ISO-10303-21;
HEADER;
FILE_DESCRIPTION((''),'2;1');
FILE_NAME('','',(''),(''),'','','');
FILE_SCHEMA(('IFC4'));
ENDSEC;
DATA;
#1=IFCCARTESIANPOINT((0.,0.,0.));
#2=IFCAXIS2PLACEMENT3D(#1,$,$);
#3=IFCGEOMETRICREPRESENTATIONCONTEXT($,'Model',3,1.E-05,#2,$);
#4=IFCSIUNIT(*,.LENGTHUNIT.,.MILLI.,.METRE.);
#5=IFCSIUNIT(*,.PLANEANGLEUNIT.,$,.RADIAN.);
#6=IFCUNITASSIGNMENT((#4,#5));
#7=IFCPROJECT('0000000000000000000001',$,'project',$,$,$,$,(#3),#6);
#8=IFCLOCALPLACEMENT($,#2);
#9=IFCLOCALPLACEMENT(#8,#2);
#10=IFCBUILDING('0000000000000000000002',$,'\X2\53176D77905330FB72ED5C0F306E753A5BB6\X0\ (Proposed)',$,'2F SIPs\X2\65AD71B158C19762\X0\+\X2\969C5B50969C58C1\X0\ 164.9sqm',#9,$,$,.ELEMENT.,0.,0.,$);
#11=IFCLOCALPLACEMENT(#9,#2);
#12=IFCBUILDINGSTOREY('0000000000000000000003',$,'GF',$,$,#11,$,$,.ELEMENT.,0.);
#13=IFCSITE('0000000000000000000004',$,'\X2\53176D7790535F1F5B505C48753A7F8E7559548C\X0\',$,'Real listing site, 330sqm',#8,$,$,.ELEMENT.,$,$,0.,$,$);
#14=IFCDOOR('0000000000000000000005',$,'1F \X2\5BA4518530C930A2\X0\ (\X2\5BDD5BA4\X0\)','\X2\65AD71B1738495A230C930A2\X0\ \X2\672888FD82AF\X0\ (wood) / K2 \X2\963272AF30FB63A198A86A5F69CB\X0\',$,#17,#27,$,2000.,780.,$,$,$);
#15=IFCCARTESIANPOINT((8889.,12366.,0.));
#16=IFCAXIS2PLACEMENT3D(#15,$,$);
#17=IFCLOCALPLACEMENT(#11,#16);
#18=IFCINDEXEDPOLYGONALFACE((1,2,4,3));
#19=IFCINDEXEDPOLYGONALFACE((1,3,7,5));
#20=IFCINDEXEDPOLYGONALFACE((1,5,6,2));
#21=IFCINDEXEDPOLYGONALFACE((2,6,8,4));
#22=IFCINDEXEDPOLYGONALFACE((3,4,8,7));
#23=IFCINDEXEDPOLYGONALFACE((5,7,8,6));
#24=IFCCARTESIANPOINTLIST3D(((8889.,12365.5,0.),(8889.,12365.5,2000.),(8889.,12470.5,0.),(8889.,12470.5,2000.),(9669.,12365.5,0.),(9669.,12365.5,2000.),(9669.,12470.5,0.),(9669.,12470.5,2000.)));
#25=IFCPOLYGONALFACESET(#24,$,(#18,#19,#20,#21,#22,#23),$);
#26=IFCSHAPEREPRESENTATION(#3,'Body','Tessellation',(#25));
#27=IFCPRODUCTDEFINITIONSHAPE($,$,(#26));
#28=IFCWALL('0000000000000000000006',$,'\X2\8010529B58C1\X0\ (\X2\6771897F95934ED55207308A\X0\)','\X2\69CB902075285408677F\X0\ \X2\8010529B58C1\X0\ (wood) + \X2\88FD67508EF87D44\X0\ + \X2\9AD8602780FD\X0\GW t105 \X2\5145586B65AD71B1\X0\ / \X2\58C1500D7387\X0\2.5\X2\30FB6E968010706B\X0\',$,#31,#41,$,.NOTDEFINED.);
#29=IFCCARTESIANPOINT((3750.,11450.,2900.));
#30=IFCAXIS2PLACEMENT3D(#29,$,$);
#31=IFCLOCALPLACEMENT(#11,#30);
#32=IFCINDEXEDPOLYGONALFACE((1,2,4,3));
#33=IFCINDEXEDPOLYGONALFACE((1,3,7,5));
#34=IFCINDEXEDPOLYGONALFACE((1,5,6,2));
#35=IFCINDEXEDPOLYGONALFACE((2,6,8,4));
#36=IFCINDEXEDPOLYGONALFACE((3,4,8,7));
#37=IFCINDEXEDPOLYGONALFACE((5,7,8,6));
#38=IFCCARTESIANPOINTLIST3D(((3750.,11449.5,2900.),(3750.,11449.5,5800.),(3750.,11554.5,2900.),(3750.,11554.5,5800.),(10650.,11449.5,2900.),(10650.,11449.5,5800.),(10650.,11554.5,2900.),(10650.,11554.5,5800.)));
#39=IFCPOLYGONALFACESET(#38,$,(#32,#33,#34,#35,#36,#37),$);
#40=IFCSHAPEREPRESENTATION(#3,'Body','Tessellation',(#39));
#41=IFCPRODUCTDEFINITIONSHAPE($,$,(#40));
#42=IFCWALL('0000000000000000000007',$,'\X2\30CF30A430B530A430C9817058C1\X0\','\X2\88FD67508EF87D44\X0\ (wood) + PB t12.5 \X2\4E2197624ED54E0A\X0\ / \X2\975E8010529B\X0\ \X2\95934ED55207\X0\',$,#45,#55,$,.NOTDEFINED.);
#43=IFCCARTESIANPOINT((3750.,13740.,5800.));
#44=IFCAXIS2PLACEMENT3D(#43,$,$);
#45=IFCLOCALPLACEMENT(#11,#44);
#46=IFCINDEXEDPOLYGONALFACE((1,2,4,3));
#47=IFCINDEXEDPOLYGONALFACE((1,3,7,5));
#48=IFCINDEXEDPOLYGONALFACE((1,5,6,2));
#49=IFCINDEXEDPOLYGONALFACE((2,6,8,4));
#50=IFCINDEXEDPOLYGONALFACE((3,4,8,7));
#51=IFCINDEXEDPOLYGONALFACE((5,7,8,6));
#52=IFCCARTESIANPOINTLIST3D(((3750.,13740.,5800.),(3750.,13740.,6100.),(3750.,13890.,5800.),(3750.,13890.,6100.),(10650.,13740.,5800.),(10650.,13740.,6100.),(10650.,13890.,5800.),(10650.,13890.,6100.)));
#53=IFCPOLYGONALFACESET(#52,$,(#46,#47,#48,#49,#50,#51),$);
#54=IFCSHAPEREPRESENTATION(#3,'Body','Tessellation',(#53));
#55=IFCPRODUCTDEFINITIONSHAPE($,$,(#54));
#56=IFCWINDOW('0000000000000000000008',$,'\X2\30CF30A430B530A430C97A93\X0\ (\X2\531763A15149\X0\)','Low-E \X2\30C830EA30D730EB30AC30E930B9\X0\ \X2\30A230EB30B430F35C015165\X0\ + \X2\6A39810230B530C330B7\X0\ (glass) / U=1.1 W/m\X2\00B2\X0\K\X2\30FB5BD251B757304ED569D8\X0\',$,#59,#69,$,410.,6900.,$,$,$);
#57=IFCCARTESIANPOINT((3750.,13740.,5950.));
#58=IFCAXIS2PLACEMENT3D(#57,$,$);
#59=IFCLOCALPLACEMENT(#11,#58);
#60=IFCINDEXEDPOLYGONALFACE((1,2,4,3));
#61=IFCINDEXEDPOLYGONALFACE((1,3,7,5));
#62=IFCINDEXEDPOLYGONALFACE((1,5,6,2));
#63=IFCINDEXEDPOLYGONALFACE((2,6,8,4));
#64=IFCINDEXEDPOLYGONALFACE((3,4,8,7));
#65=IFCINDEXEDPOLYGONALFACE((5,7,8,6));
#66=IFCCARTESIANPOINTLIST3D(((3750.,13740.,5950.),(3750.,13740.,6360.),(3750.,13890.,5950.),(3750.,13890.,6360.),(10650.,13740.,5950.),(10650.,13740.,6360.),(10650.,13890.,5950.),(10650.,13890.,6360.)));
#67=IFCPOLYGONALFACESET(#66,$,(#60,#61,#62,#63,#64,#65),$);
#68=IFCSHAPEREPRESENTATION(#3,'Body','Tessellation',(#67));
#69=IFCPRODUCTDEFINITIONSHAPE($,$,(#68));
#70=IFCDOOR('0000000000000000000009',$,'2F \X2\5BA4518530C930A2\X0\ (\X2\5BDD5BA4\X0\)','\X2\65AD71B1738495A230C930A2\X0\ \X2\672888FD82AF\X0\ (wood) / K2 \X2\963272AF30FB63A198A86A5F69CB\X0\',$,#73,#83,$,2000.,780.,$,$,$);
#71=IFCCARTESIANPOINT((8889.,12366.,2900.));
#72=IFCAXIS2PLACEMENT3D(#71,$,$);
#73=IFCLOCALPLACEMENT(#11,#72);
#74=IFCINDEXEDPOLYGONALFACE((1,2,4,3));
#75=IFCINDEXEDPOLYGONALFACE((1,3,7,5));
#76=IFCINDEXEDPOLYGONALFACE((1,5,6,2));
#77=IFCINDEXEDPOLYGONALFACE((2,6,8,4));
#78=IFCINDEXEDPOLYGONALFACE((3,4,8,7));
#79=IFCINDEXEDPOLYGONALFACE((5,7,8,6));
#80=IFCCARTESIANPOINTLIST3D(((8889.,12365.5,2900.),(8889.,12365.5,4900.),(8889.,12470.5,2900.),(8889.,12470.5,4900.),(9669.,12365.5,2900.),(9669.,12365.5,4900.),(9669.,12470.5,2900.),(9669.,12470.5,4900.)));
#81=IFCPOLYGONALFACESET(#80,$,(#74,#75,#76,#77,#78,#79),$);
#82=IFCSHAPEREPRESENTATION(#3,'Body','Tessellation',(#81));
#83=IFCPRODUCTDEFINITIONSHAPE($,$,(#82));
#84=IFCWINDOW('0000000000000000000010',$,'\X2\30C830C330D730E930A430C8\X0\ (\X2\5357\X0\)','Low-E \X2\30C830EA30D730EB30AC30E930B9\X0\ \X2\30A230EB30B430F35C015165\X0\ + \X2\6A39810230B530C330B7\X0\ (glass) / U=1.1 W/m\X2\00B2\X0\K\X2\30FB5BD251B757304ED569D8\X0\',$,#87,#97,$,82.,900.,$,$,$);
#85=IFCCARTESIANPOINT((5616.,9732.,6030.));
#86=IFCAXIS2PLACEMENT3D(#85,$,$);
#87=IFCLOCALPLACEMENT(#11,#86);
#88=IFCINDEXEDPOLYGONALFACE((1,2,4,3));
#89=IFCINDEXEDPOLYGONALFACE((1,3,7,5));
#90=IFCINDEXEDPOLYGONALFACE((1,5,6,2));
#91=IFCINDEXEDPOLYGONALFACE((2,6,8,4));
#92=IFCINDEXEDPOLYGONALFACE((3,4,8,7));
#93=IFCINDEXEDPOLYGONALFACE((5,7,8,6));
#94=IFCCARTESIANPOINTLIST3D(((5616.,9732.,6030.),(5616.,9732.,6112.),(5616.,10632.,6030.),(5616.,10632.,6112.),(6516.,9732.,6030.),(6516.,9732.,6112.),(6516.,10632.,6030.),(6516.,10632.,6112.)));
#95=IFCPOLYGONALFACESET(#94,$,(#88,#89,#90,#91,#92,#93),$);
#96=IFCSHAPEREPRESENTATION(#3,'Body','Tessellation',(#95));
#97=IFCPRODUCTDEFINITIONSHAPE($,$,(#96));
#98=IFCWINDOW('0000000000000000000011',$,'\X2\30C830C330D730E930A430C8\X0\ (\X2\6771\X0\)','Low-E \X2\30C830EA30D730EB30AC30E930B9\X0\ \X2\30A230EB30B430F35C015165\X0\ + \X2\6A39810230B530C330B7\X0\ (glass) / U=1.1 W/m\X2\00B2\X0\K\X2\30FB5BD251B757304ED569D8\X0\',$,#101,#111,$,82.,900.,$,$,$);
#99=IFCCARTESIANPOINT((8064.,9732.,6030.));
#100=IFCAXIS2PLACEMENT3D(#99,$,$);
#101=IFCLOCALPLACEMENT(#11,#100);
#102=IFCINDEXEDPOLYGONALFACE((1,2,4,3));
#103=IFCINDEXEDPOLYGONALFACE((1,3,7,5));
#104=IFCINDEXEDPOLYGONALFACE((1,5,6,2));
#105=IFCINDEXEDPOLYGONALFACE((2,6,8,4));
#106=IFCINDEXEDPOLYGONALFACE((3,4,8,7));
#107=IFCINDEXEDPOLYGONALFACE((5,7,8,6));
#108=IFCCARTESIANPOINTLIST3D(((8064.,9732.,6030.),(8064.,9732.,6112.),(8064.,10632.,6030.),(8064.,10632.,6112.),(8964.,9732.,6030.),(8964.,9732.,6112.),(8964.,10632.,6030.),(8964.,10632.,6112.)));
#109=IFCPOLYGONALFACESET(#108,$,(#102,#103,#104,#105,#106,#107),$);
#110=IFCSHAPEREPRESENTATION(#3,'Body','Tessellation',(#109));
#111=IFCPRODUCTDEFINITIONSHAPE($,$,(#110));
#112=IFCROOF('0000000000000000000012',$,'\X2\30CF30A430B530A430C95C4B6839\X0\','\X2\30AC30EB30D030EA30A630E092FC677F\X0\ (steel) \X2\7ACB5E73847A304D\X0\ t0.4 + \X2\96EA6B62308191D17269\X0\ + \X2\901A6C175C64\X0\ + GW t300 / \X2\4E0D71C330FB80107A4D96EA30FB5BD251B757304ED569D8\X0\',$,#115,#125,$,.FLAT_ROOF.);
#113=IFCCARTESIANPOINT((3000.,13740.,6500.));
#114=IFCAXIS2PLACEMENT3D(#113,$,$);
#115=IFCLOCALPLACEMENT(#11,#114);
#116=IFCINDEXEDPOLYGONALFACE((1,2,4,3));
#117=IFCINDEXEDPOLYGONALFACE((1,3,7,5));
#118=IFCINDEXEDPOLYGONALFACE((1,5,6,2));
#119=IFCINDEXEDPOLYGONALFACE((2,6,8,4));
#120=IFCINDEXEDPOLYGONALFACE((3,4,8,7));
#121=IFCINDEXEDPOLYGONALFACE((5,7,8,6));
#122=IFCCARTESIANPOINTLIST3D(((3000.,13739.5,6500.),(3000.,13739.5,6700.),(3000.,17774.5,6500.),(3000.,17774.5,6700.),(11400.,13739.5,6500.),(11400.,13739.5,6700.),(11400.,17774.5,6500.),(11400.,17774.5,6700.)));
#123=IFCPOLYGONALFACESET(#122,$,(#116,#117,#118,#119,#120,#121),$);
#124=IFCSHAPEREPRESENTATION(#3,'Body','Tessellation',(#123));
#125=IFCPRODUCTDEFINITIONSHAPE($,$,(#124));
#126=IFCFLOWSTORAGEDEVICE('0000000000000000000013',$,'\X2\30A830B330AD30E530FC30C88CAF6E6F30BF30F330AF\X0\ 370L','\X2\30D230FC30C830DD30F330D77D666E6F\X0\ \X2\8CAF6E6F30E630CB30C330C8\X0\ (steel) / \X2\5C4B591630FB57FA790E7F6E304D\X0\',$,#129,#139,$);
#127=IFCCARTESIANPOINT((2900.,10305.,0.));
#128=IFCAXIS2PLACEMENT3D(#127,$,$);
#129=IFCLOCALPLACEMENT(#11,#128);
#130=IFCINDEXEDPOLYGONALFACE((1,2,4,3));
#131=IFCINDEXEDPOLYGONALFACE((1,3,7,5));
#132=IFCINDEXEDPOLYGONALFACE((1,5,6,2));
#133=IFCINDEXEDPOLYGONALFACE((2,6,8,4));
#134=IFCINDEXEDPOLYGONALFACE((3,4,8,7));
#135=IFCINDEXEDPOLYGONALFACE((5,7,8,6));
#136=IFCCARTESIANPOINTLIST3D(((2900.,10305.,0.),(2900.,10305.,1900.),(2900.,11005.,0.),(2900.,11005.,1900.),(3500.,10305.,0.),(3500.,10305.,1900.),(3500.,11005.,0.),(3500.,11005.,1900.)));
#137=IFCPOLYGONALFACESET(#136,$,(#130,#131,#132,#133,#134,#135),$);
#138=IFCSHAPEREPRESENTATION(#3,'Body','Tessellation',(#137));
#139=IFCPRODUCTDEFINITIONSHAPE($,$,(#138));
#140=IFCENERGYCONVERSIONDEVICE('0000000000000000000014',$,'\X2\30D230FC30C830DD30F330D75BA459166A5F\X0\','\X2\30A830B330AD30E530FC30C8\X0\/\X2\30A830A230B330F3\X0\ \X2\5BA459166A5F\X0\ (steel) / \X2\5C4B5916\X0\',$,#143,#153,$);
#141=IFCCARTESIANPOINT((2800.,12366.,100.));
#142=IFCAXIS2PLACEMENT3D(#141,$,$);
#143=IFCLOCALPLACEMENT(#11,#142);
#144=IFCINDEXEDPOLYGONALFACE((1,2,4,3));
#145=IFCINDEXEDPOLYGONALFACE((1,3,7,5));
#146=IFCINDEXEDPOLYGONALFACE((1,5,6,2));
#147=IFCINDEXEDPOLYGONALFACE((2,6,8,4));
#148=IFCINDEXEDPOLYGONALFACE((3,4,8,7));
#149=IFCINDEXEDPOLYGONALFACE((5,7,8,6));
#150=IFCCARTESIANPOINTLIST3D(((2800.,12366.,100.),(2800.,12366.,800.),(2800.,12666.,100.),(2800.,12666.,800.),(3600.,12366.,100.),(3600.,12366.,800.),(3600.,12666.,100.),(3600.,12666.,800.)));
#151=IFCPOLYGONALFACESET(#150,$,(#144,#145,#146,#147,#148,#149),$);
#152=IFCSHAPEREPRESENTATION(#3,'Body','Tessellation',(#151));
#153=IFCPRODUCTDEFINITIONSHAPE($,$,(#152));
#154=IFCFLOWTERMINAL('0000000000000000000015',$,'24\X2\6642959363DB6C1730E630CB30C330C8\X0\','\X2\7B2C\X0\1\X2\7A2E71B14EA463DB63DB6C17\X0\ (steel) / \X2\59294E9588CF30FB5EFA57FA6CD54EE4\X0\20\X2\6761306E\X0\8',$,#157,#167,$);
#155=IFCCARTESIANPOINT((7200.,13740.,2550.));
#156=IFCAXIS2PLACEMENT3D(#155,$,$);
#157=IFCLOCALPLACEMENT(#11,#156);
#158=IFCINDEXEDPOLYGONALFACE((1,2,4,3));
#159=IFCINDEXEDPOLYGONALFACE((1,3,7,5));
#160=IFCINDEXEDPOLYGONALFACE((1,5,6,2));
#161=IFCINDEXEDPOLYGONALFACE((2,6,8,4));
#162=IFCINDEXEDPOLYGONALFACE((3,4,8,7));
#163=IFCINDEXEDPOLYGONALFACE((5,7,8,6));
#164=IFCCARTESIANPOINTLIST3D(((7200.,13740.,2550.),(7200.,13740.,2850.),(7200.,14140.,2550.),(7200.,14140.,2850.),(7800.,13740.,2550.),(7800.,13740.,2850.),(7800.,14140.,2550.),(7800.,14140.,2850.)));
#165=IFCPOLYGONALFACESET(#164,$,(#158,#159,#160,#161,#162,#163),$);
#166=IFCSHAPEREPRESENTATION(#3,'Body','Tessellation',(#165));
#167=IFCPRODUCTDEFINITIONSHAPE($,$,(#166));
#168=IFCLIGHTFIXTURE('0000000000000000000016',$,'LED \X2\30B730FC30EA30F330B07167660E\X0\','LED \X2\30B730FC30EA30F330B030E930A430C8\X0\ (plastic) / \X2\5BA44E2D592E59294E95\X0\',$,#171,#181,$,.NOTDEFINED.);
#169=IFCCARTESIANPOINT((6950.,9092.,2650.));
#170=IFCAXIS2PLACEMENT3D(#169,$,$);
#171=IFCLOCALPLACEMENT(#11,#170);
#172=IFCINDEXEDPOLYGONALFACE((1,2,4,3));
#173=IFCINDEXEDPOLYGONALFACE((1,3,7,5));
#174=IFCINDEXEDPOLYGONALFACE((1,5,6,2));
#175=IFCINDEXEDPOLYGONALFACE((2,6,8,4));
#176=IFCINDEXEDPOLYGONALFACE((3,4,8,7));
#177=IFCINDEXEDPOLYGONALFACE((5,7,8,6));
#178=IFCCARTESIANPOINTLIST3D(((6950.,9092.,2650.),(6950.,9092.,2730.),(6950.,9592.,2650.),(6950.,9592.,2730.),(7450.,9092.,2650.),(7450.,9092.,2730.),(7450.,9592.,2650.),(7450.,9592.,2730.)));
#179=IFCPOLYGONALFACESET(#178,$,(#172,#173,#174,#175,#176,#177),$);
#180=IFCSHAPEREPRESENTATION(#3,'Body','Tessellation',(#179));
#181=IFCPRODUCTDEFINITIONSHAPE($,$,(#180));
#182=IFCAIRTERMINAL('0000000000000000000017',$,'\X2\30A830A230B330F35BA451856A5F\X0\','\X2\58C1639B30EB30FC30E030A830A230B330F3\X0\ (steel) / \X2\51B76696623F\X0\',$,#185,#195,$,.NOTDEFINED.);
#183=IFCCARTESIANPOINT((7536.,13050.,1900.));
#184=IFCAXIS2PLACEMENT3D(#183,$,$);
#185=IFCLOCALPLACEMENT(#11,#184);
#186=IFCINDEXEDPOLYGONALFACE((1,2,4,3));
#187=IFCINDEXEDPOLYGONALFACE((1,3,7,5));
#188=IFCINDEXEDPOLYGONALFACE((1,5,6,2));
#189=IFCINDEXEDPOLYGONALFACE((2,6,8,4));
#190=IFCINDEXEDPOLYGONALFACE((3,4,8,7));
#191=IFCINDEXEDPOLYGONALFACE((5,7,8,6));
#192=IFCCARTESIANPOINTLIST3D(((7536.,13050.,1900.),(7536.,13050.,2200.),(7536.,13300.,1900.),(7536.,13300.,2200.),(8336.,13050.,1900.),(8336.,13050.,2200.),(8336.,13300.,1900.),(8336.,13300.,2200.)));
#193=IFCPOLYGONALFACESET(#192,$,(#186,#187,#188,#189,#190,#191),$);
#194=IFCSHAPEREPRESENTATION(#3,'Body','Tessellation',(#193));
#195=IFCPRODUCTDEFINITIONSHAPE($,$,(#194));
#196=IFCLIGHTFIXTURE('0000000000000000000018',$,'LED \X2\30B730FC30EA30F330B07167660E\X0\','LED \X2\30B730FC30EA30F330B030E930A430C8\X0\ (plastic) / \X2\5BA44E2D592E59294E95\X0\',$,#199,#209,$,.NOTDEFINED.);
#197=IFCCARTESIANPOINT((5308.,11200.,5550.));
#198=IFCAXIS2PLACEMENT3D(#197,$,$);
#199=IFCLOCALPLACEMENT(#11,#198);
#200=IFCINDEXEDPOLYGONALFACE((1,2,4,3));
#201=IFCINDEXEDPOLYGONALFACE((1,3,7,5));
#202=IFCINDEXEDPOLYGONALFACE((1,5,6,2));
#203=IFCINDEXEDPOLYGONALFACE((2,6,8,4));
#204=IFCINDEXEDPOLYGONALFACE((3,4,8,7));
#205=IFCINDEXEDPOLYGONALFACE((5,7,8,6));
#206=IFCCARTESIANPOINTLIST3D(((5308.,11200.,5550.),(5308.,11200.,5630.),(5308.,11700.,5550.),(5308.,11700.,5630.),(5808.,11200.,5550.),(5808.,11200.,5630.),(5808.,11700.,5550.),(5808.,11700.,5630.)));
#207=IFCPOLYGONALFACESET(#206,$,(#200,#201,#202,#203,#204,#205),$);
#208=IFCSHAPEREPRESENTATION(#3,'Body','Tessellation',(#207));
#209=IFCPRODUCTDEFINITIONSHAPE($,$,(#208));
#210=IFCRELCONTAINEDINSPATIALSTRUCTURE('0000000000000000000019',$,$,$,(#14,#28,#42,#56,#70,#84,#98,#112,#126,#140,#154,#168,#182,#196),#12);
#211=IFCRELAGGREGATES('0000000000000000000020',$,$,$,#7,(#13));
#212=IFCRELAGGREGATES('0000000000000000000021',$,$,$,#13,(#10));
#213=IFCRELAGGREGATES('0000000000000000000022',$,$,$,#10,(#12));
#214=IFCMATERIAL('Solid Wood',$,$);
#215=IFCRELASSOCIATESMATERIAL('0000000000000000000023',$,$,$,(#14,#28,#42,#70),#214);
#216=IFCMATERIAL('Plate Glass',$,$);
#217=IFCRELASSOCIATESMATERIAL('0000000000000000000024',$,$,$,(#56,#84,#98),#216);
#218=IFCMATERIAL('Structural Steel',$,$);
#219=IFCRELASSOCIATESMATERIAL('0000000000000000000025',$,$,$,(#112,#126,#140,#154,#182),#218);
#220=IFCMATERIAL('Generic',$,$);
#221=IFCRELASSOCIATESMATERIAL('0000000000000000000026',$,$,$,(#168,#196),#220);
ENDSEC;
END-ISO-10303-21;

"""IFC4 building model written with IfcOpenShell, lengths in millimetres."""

from ifc_helpers import new_model, si_unit, frame, frame_2d, origin, place, context, project, spatial, rectangle, extrude, material, element, fill, save


model = new_model("IFC4")

# Units and contexts
model_context = context("Model", 3, precision=1e-05, world=origin())
ifc_project = project(units=[si_unit("LENGTHUNIT", "METRE", prefix="MILLI"), si_unit("PLANEANGLEUNIT", "RADIAN")], contexts=[model_context])

# Site, building, storey
site_placement = place(None, origin())
site = spatial("IfcSite", under=ifc_project, at=site_placement, Name="北海道弟子屈町美留和", ObjectType="Real listing site, 330sqm", CompositionType="ELEMENT", RefElevation=0.0)
building_placement = place(site_placement, origin())
building = spatial("IfcBuilding", under=site, at=building_placement, Name="北海道・狭小の町家 (Proposed)", ObjectType="2F SIPs断熱壁面+障子障壁 164.9sqm", CompositionType="ELEMENT", ElevationOfRefHeight=0.0, ElevationOfTerrain=0.0)
storey_placement = place(building_placement, origin())
storey = spatial("IfcBuildingStorey", under=building, at=storey_placement, Name="GF", CompositionType="ELEMENT", Elevation=0.0)

# Shared definitions
ifc_material_1 = material(Name="Solid Wood")

# Door
door_1_placement = place(storey_placement, frame((8889.0, 12366.0, 0.0)))
element("IfcDoor", 1, at=door_1_placement, inside=storey, material=ifc_material_1, Name="1F 室内ドア (寝室)", Description="断熱玄関ドア 木製芯 (wood) / K2 防犯・採風機構", OverallHeight=2000.0, OverallWidth=780.0, context=model_context, shape_type="SweptSolid", body=[
    extrude(rectangle(XDim=780.0, YDim=105.0, at=frame_2d((390.0, 52.0))), frame((8889.0, 12366.0, 0.0)), (0.0, 0.0, 1.0), 2000.0),
])

# Wall
wall_1_placement = place(storey_placement, frame((3750.0, 11450.0, 2900.0)))
element("IfcWall", 2, at=wall_1_placement, inside=storey, material=ifc_material_1, Name="耐力壁 (東西間仕切り)", Description="構造用合板 耐力壁 (wood) + 製材軸組 + 高性能GW t105 充填断熱 / 壁倍率2.5・準耐火", PredefinedType="NOTDEFINED", context=model_context, shape_type="SweptSolid", body=[
    extrude(rectangle(XDim=6900.0, YDim=105.0, at=frame_2d((3450.0, 52.0))), frame((3750.0, 11450.0, 2900.0)), (0.0, 0.0, 1.0), 2900.0),
])

# Wall, opening, window
wall_2_placement = place(storey_placement, frame((3750.0, 13740.0, 5800.0)))
wall_2 = element("IfcWall", 3, at=wall_2_placement, inside=storey, material=ifc_material_1, Name="ハイサイド腰壁", Description="製材軸組 (wood) + PB t12.5 両面仕上 / 非耐力 間仕切", PredefinedType="NOTDEFINED", context=model_context, shape_type="SweptSolid", body=[
    extrude(rectangle(XDim=6900.0, YDim=150.0, at=frame_2d((3450.0, 75.0))), frame((3750.0, 13740.0, 5800.0)), (0.0, 0.0, 1.0), 700.0),
])
opening_1_placement = place(storey_placement, frame((3750.0, 13740.0, 5950.0)))
opening_1 = element("IfcOpeningElement", 4, at=opening_1_placement, cuts=wall_2, PredefinedType="NOTDEFINED", context=model_context, shape_type="SweptSolid", body=[
    extrude(rectangle(XDim=6900.0, YDim=150.0, at=frame_2d((3450.0, 75.0))), frame((3750.0, 13740.0, 5950.0)), (0.0, 0.0, 1.0), 410.0),
])
ifc_material_2 = material(Name="Plate Glass")
window_1_placement = place(storey_placement, frame((3750.0, 13740.0, 5950.0)))
window_1 = element("IfcWindow", 5, at=window_1_placement, inside=storey, material=ifc_material_2, Name="ハイサイド窓 (北採光)", Description="Low-E トリプルガラス アルゴン封入 + 樹脂サッシ (glass) / U=1.1 W/m²K・寒冷地仕様", OverallHeight=410.0, OverallWidth=6900.0, context=model_context, shape_type="SweptSolid", body=[
    extrude(rectangle(XDim=6900.0, YDim=150.0, at=frame_2d((3450.0, 75.0))), frame((3750.0, 13740.0, 5950.0)), (0.0, 0.0, 1.0), 410.0),
])
fill(opening_1, window_1)

# Door
door_2_placement = place(storey_placement, frame((8889.0, 12366.0, 2900.0)))
element("IfcDoor", 6, at=door_2_placement, inside=storey, material=ifc_material_1, Name="2F 室内ドア (寝室)", Description="断熱玄関ドア 木製芯 (wood) / K2 防犯・採風機構", OverallHeight=2000.0, OverallWidth=780.0, context=model_context, shape_type="SweptSolid", body=[
    extrude(rectangle(XDim=780.0, YDim=105.0, at=frame_2d((390.0, 52.0))), frame((8889.0, 12366.0, 2900.0)), (0.0, 0.0, 1.0), 2000.0),
])

# Windows
window_2_placement = place(storey_placement, frame((5616.0, 9732.0, 6030.0)))
element("IfcWindow", 7, at=window_2_placement, inside=storey, material=ifc_material_2, Name="トップライト (南)", Description="Low-E トリプルガラス アルゴン封入 + 樹脂サッシ (glass) / U=1.1 W/m²K・寒冷地仕様", OverallHeight=82.0, OverallWidth=900.0, context=model_context, shape_type="SweptSolid", body=[
    extrude(rectangle(XDim=900.0, YDim=900.0, at=frame_2d((450.0, 450.0))), frame((5616.0, 9732.0, 6030.0)), (0.0, 0.0, 1.0), 82.0),
])
window_3_placement = place(storey_placement, frame((8064.0, 9732.0, 6030.0)))
element("IfcWindow", 8, at=window_3_placement, inside=storey, material=ifc_material_2, Name="トップライト (東)", Description="Low-E トリプルガラス アルゴン封入 + 樹脂サッシ (glass) / U=1.1 W/m²K・寒冷地仕様", OverallHeight=82.0, OverallWidth=900.0, context=model_context, shape_type="SweptSolid", body=[
    extrude(rectangle(XDim=900.0, YDim=900.0, at=frame_2d((450.0, 450.0))), frame((8064.0, 9732.0, 6030.0)), (0.0, 0.0, 1.0), 82.0),
])

# Roof
ifc_material_3 = material(Name="Structural Steel")
roof_placement = place(storey_placement, frame((3000.0, 13740.0, 6500.0)))
element("IfcRoof", 9, at=roof_placement, inside=storey, material=ifc_material_3, Name="ハイサイド屋根", Description="ガルバリウム鋼板 (steel) 立平葺き t0.4 + 雪止め金物 + 通気層 + GW t300 / 不燃・耐積雪・寒冷地仕様", PredefinedType="FLAT_ROOF", context=model_context, shape_type="SweptSolid", body=[
    extrude(rectangle(XDim=8400.0, YDim=4035.0, at=frame_2d((4200.0, 2017.0))), frame((3000.0, 13740.0, 6500.0)), (0.0, 0.0, 1.0), 200.0),
])

# Flow storage device
flow_storage_device_placement = place(storey_placement, frame((2900.0, 10305.0, 0.0)))
element("IfcFlowStorageDevice", 10, at=flow_storage_device_placement, inside=storey, material=ifc_material_3, Name="エコキュート貯湯タンク 370L", Description="ヒートポンプ給湯 貯湯ユニット (steel) / 屋外・基礎置き", context=model_context, shape_type="SweptSolid", body=[
    extrude(rectangle(XDim=600.0, YDim=700.0, at=frame_2d((300.0, 350.0))), frame((2900.0, 10305.0, 0.0)), (0.0, 0.0, 1.0), 1900.0),
])

# Energy conversion device
energy_conversion_device_placement = place(storey_placement, frame((2800.0, 12366.0, 100.0)))
element("IfcEnergyConversionDevice", 11, at=energy_conversion_device_placement, inside=storey, material=ifc_material_3, Name="ヒートポンプ室外機", Description="エコキュート/エアコン 室外機 (steel) / 屋外", context=model_context, shape_type="SweptSolid", body=[
    extrude(rectangle(XDim=800.0, YDim=300.0, at=frame_2d((400.0, 150.0))), frame((2800.0, 12366.0, 100.0)), (0.0, 0.0, 1.0), 700.0),
])

# Flow terminal
flow_terminal_placement = place(storey_placement, frame((7200.0, 13740.0, 2550.0)))
element("IfcFlowTerminal", 12, at=flow_terminal_placement, inside=storey, material=ifc_material_3, Name="24時間換気ユニット", Description="第1種熱交換換気 (steel) / 天井裏・建基法令20条の8", context=model_context, shape_type="SweptSolid", body=[
    extrude(rectangle(XDim=600.0, YDim=400.0, at=frame_2d((300.0, 200.0))), frame((7200.0, 13740.0, 2550.0)), (0.0, 0.0, 1.0), 300.0),
])

# Light fixture
ifc_material_4 = material(Name="Generic")
light_fixture_1_placement = place(storey_placement, frame((6950.0, 9092.0, 2650.0)))
element("IfcLightFixture", 13, at=light_fixture_1_placement, inside=storey, material=ifc_material_4, Name="LED シーリング照明", Description="LED シーリングライト (plastic) / 室中央天井", PredefinedType="NOTDEFINED", context=model_context, shape_type="SweptSolid", body=[
    extrude(rectangle(XDim=500.0, YDim=500.0, at=frame_2d((250.0, 250.0))), frame((6950.0, 9092.0, 2650.0)), (0.0, 0.0, 1.0), 80.0),
])

# Air terminal
air_terminal_placement = place(storey_placement, frame((7536.0, 13050.0, 1900.0)))
element("IfcAirTerminal", 14, at=air_terminal_placement, inside=storey, material=ifc_material_3, Name="エアコン室内機", Description="壁掛ルームエアコン (steel) / 冷暖房", PredefinedType="NOTDEFINED", context=model_context, shape_type="SweptSolid", body=[
    extrude(rectangle(XDim=800.0, YDim=250.0, at=frame_2d((400.0, 125.0))), frame((7536.0, 13050.0, 1900.0)), (0.0, 0.0, 1.0), 300.0),
])

# Light fixture
light_fixture_2_placement = place(storey_placement, frame((5308.0, 11200.0, 5550.0)))
element("IfcLightFixture", 15, at=light_fixture_2_placement, inside=storey, material=ifc_material_4, Name="LED シーリング照明", Description="LED シーリングライト (plastic) / 室中央天井", PredefinedType="NOTDEFINED", context=model_context, shape_type="SweptSolid", body=[
    extrude(rectangle(XDim=500.0, YDim=500.0, at=frame_2d((250.0, 250.0))), frame((5308.0, 11200.0, 5550.0)), (0.0, 0.0, 1.0), 80.0),
])

save(model, "model.ifc")
